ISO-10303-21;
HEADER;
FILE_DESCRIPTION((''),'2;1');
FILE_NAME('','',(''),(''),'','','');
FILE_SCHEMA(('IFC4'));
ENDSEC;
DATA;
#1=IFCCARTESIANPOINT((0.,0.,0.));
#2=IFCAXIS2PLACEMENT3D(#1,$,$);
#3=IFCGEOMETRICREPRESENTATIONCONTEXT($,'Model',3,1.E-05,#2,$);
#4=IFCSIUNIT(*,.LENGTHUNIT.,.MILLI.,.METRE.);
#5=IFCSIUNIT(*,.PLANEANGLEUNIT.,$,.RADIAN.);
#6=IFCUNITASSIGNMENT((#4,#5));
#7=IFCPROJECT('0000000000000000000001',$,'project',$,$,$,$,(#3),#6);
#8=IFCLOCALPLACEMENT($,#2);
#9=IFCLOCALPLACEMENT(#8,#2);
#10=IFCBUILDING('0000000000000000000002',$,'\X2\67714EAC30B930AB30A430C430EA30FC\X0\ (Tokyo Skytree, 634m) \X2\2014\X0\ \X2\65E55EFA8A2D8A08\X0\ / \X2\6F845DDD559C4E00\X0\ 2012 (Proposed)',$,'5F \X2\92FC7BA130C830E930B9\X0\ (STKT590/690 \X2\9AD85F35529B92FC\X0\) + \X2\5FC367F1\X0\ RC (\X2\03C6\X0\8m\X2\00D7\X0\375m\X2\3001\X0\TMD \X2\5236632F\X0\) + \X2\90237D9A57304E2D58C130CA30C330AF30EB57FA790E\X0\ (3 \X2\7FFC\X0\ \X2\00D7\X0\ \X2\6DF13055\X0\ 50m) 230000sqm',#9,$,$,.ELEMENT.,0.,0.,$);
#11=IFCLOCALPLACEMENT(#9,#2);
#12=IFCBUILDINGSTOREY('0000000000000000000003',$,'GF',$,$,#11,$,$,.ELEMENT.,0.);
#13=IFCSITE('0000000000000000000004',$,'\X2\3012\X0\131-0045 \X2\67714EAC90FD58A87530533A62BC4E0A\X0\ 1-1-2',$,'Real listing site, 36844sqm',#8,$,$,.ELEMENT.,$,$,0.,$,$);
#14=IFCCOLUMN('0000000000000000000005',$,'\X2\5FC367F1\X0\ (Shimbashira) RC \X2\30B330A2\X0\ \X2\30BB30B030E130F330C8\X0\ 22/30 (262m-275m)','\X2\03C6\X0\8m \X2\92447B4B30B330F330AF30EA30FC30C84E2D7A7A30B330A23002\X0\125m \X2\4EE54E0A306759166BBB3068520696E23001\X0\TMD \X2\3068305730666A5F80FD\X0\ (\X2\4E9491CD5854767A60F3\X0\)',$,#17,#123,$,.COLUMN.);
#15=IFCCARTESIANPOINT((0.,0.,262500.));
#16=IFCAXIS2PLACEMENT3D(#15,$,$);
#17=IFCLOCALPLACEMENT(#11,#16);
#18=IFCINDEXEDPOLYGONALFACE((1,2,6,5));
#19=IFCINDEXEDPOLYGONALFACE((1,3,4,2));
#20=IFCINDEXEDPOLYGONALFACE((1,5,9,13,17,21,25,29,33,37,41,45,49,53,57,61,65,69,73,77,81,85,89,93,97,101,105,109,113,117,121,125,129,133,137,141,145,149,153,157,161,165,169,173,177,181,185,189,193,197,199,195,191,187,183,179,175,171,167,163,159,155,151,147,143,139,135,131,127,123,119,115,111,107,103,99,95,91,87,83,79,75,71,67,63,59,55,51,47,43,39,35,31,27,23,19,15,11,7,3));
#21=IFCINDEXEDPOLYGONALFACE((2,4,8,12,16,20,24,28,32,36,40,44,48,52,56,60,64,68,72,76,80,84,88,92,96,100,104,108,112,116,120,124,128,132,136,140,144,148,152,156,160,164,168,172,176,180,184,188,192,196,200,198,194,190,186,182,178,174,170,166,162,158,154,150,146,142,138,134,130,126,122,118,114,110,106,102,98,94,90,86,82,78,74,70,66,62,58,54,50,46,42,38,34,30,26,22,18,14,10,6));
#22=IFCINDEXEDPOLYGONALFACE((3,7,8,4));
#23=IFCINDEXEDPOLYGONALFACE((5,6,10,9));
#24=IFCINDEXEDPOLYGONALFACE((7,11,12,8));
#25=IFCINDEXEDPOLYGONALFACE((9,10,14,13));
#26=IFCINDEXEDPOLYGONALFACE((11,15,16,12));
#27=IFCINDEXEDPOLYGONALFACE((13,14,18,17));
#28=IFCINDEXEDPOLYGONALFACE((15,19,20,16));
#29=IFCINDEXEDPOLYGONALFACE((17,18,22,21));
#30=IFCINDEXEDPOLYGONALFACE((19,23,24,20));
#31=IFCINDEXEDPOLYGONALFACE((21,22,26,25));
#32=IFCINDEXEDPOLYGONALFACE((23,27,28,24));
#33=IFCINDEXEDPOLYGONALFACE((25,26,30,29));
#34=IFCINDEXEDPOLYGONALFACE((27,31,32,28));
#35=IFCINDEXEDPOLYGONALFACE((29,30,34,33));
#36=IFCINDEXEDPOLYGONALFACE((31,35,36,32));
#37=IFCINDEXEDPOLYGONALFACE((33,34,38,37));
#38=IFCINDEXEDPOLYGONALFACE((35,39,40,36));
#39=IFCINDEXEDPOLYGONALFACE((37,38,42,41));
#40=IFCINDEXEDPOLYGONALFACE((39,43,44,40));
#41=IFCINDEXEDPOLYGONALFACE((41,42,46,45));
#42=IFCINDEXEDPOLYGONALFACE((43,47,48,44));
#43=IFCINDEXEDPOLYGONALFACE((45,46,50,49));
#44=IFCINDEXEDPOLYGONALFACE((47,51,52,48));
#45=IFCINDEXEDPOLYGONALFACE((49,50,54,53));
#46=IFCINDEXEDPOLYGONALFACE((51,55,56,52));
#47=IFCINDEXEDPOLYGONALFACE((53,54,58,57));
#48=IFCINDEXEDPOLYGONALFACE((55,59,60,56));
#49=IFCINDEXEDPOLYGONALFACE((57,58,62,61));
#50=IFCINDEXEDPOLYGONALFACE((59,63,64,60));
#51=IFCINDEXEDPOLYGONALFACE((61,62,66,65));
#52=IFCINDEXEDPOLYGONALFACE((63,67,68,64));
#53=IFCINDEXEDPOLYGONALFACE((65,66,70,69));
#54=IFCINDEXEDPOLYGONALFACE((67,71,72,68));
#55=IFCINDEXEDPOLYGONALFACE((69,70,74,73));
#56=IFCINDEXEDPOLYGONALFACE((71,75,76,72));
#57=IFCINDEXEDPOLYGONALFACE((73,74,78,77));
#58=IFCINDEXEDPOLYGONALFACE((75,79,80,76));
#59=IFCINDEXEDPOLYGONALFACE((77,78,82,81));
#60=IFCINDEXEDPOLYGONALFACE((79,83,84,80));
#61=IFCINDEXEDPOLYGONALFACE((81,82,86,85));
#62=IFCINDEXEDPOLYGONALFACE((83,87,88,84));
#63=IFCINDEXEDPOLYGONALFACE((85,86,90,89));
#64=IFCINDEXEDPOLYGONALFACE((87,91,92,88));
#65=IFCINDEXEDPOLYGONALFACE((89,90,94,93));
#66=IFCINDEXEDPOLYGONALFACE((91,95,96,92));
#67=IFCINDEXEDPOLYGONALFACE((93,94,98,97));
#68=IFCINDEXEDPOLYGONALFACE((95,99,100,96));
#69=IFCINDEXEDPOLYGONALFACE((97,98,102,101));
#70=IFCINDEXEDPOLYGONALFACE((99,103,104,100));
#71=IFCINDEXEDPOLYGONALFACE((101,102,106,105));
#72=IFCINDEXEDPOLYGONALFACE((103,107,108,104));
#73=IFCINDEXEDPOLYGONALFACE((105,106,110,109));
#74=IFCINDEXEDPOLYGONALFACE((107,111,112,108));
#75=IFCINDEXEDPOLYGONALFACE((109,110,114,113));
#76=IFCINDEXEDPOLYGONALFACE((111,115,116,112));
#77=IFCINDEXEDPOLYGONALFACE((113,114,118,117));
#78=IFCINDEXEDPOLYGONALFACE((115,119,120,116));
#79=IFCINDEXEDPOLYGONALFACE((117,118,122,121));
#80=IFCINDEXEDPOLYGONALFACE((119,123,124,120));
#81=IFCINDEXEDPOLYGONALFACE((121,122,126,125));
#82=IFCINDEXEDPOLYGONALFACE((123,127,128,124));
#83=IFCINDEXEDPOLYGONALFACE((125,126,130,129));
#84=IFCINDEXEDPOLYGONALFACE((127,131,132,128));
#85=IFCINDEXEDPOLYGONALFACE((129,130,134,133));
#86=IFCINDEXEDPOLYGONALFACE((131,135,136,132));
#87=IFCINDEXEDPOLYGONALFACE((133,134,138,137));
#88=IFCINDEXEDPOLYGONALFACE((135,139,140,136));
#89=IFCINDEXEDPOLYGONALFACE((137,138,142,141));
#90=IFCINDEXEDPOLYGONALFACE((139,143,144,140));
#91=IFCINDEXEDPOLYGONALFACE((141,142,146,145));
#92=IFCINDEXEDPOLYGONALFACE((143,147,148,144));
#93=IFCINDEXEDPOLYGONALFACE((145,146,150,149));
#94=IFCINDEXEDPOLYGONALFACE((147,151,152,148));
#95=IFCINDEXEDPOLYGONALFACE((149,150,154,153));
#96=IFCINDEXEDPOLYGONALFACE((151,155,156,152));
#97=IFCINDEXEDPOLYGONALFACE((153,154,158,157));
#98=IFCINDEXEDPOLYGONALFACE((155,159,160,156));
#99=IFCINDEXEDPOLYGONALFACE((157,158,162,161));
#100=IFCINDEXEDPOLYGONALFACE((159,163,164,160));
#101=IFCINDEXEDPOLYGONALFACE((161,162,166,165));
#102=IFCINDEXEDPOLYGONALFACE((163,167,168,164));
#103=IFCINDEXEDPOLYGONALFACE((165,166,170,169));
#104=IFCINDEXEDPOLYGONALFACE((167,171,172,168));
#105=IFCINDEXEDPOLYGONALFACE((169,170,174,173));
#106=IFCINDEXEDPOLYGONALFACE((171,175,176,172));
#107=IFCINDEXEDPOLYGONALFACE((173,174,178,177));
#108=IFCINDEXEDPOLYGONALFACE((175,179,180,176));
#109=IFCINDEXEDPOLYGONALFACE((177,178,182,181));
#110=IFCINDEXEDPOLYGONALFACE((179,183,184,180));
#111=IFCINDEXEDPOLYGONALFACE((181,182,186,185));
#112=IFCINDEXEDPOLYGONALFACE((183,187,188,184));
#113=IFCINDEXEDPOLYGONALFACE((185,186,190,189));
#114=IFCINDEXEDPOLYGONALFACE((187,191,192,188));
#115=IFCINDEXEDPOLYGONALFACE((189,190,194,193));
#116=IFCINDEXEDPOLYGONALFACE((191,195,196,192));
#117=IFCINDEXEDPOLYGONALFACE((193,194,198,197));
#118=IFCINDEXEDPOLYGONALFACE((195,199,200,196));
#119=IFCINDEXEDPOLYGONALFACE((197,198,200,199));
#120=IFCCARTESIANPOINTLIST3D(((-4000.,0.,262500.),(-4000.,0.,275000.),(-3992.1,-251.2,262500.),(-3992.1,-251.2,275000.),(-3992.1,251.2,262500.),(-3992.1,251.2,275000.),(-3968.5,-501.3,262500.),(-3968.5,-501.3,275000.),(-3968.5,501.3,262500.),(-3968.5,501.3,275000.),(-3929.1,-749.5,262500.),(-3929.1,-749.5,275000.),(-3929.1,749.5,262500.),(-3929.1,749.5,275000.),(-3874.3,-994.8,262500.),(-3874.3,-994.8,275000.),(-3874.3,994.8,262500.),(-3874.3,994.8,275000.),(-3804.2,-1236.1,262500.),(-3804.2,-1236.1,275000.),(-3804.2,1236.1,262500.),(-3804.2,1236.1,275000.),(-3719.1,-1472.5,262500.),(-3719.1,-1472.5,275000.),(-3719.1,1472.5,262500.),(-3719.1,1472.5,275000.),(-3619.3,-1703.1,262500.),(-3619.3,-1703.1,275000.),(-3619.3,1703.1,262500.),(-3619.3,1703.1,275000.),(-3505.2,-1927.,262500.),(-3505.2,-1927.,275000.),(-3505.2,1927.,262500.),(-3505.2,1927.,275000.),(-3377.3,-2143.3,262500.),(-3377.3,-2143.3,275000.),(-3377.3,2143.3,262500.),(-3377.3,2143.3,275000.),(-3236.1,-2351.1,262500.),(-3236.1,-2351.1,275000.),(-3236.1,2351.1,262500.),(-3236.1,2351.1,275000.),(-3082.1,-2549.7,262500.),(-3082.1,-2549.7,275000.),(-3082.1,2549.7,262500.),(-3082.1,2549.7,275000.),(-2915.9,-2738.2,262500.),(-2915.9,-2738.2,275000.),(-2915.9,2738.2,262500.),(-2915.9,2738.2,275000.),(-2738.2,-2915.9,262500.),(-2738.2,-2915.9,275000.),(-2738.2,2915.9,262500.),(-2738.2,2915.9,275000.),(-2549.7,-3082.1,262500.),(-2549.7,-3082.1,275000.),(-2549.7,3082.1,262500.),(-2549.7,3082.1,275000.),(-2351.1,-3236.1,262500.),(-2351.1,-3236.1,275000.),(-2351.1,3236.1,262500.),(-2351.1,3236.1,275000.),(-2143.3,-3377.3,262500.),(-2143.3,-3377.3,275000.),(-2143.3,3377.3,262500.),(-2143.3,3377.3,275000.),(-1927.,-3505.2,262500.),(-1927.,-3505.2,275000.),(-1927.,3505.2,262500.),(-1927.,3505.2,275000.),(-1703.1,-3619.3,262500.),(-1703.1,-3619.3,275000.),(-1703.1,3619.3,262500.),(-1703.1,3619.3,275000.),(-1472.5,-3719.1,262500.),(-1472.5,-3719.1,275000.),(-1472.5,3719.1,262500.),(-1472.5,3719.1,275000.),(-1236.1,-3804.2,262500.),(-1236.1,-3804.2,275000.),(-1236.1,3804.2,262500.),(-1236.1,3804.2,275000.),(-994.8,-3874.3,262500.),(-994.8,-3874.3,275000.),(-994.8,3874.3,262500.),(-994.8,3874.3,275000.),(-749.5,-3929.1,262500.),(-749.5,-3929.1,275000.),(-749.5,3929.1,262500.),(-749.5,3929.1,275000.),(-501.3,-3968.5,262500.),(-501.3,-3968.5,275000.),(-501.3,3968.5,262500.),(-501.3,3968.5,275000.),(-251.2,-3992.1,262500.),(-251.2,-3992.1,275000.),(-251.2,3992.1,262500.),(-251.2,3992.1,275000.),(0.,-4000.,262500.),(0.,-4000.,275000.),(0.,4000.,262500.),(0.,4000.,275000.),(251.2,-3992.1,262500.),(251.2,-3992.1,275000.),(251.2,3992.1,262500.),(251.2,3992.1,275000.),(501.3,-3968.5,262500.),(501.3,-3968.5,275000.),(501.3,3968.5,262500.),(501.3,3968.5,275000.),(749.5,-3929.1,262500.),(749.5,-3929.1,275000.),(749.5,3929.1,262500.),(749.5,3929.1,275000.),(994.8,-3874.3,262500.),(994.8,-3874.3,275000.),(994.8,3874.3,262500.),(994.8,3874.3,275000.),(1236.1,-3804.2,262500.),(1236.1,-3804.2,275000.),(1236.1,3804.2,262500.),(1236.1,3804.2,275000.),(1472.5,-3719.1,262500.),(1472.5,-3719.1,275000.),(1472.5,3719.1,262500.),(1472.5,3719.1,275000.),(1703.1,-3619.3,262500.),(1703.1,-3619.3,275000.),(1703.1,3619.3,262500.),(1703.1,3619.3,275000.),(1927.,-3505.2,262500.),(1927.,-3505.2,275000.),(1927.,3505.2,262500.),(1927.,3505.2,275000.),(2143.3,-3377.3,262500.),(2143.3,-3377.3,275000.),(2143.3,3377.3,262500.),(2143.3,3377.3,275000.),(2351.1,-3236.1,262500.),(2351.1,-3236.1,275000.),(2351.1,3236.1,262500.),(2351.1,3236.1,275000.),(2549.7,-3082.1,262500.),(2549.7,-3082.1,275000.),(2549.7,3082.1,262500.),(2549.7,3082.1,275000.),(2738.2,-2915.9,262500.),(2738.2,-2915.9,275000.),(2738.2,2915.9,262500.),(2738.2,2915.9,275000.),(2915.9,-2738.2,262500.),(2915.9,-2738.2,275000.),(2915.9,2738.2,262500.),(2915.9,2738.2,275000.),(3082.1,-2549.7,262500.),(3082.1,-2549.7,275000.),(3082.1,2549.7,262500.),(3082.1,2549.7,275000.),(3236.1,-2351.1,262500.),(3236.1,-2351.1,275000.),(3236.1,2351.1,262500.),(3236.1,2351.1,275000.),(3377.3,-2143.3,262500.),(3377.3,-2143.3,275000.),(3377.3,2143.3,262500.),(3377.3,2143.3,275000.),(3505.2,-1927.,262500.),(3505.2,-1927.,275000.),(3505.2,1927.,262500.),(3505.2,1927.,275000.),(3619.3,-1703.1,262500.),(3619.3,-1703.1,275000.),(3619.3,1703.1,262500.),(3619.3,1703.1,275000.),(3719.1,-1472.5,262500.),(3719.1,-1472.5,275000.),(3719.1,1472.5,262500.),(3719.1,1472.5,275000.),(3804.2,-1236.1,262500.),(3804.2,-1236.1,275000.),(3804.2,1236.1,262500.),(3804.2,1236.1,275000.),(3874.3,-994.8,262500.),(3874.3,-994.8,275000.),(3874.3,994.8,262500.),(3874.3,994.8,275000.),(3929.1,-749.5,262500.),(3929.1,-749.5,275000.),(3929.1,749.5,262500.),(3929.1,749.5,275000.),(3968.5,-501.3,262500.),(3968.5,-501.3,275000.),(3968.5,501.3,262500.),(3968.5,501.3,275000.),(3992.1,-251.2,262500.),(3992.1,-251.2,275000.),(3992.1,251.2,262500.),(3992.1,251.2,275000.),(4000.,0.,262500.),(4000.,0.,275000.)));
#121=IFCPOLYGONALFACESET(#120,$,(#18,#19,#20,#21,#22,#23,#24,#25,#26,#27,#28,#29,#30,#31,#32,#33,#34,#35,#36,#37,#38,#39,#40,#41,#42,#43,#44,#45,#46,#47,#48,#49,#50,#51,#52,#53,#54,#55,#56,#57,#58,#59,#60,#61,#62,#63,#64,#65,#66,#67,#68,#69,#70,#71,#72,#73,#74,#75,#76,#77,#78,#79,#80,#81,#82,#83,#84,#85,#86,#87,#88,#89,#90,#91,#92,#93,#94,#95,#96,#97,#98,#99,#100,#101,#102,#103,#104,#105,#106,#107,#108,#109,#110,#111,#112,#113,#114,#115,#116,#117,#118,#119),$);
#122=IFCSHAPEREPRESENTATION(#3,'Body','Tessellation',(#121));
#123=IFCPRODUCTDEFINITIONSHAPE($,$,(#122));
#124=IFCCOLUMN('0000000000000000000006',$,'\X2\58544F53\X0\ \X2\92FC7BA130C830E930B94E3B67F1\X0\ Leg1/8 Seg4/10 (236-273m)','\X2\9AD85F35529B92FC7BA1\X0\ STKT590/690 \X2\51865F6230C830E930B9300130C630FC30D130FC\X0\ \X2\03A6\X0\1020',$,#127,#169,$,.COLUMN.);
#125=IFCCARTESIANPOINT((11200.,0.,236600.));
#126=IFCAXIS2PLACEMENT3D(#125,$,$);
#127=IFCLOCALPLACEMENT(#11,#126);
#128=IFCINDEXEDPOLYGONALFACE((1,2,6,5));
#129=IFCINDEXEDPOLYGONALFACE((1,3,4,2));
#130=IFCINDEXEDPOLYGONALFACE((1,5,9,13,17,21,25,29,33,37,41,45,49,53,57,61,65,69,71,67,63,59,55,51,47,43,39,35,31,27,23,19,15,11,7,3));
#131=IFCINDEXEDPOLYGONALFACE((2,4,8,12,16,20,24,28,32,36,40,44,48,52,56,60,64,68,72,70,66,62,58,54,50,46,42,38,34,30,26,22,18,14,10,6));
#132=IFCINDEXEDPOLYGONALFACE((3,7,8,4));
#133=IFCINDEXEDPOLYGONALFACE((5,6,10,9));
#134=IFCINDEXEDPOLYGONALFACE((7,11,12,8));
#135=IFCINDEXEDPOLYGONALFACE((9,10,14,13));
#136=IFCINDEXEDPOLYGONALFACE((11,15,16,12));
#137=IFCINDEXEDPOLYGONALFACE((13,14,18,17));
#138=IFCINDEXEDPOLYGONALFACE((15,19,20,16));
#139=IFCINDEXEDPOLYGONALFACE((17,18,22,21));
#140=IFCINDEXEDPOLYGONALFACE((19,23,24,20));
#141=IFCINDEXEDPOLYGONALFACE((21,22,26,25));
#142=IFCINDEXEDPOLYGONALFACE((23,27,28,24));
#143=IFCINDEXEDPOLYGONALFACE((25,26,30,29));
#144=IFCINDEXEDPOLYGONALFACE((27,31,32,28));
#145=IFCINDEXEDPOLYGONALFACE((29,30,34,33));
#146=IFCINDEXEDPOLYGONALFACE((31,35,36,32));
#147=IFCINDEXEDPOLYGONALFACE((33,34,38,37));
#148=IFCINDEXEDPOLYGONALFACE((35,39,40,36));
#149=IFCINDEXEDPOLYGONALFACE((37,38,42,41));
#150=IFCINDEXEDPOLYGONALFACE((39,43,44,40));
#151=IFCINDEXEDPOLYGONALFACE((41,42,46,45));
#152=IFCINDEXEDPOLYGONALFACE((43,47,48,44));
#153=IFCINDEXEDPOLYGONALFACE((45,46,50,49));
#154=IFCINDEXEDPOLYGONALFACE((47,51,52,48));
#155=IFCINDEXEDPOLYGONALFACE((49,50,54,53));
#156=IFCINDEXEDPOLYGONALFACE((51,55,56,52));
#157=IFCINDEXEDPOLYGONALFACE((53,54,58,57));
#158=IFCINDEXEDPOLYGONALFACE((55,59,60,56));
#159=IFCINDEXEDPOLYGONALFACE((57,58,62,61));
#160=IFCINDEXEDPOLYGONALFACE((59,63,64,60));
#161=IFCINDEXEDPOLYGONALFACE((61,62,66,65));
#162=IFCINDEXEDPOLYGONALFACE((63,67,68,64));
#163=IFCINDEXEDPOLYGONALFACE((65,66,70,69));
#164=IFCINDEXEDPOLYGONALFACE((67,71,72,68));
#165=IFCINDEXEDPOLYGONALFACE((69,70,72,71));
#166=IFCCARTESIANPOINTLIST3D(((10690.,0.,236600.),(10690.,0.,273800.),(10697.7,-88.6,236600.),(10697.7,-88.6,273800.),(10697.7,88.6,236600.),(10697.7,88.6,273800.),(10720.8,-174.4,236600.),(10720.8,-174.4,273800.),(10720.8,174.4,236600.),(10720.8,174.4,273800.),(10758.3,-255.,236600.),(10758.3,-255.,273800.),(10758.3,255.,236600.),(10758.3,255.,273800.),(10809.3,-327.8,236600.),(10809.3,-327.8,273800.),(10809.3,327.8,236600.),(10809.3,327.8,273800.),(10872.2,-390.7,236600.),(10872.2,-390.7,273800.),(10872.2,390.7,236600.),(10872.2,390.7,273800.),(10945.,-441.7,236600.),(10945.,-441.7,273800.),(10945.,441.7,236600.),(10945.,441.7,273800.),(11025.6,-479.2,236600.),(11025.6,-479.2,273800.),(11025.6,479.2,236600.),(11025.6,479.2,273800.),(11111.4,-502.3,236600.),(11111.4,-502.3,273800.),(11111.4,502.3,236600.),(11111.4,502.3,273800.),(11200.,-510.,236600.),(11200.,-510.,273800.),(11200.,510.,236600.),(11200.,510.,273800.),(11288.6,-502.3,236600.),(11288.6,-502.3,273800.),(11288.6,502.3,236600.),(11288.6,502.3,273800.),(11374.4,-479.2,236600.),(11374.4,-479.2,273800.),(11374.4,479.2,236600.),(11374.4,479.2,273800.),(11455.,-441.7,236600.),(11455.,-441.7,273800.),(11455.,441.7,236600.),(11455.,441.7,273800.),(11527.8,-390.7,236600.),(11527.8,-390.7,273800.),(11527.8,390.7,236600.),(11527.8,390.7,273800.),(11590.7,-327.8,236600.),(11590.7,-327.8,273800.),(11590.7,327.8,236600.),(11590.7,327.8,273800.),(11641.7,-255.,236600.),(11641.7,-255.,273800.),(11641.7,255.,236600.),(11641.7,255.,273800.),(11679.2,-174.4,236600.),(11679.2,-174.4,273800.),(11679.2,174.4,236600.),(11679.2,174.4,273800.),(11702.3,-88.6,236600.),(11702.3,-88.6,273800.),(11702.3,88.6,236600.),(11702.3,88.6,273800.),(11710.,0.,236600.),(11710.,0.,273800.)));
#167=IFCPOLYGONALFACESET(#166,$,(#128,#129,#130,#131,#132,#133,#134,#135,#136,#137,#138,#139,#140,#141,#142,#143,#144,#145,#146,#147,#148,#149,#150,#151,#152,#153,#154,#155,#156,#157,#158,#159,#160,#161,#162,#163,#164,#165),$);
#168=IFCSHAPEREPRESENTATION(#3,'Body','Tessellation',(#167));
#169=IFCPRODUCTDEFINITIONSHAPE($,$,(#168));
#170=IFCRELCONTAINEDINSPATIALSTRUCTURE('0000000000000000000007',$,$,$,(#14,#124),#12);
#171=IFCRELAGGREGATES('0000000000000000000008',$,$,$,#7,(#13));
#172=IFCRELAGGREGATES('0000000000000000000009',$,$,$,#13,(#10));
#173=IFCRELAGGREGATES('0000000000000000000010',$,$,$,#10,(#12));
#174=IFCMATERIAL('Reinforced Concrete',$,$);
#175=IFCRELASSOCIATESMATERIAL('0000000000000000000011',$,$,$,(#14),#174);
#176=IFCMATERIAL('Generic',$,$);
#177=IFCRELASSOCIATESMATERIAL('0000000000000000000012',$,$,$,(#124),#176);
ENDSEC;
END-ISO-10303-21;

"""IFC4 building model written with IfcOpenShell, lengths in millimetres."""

from ifc_helpers import new_model, si_unit, frame, origin, origin_2d, place, context, project, spatial, circle, extrude, material, element, save


model = new_model("IFC4")

# Units and contexts
model_context = context("Model", 3, precision=1e-05, world=origin())
ifc_project = project(units=[si_unit("LENGTHUNIT", "METRE", prefix="MILLI"), si_unit("PLANEANGLEUNIT", "RADIAN")], contexts=[model_context])

# Site, building, storey
site_placement = place(None, origin())
site = spatial("IfcSite", under=ifc_project, at=site_placement, Name="〒131-0045 東京都墨田区押上 1-1-2", ObjectType="Real listing site, 36844sqm", CompositionType="ELEMENT", RefElevation=0.0)
building_placement = place(site_placement, origin())
building = spatial("IfcBuilding", under=site, at=building_placement, Name="東京スカイツリー (Tokyo Skytree, 634m) — 日建設計 / 澄川喜一 2012 (Proposed)", ObjectType="5F 鋼管トラス (STKT590/690 高張力鋼) + 心柱 RC (φ8m×375m、TMD 制振) + 連続地中壁ナックル基礎 (3 翼 × 深さ 50m) 230000sqm", CompositionType="ELEMENT", ElevationOfRefHeight=0.0, ElevationOfTerrain=0.0)
storey_placement = place(building_placement, origin())
storey = spatial("IfcBuildingStorey", under=building, at=storey_placement, Name="GF", CompositionType="ELEMENT", Elevation=0.0)

# Columns
ifc_material_1 = material(Name="Reinforced Concrete")
column_1_placement = place(storey_placement, frame((0.0, 0.0, 262500.0)))
element("IfcColumn", 1, at=column_1_placement, inside=storey, material=ifc_material_1, Name="心柱 (Shimbashira) RC コア セグメント 22/30 (262m-275m)", Description="φ8m 鉄筋コンクリート中空コア。125m 以上で外殻と分離、TMD として機能 (五重塔発想)", PredefinedType="COLUMN", context=model_context, shape_type="SweptSolid", body=[
    extrude(circle(Radius=4000.0, at=origin_2d()), frame((0.0, 0.0, 262500.0)), (0.0, 0.0, 1.0), 12500.0),
])
ifc_material_2 = material(Name="Generic")
column_2_placement = place(storey_placement, frame((11200.0, 0.0, 236600.0)))
element("IfcColumn", 2, at=column_2_placement, inside=storey, material=ifc_material_2, Name="塔体 鋼管トラス主柱 Leg1/8 Seg4/10 (236-273m)", Description="高張力鋼管 STKT590/690 円形トラス、テーパー Φ1020", PredefinedType="COLUMN", context=model_context, shape_type="SweptSolid", body=[
    extrude(circle(Radius=510.0, at=origin_2d()), frame((11200.0, 0.0, 236600.0)), (0.0, 0.0, 1.0), 37200.0),
])

save(model, "model.ifc")
